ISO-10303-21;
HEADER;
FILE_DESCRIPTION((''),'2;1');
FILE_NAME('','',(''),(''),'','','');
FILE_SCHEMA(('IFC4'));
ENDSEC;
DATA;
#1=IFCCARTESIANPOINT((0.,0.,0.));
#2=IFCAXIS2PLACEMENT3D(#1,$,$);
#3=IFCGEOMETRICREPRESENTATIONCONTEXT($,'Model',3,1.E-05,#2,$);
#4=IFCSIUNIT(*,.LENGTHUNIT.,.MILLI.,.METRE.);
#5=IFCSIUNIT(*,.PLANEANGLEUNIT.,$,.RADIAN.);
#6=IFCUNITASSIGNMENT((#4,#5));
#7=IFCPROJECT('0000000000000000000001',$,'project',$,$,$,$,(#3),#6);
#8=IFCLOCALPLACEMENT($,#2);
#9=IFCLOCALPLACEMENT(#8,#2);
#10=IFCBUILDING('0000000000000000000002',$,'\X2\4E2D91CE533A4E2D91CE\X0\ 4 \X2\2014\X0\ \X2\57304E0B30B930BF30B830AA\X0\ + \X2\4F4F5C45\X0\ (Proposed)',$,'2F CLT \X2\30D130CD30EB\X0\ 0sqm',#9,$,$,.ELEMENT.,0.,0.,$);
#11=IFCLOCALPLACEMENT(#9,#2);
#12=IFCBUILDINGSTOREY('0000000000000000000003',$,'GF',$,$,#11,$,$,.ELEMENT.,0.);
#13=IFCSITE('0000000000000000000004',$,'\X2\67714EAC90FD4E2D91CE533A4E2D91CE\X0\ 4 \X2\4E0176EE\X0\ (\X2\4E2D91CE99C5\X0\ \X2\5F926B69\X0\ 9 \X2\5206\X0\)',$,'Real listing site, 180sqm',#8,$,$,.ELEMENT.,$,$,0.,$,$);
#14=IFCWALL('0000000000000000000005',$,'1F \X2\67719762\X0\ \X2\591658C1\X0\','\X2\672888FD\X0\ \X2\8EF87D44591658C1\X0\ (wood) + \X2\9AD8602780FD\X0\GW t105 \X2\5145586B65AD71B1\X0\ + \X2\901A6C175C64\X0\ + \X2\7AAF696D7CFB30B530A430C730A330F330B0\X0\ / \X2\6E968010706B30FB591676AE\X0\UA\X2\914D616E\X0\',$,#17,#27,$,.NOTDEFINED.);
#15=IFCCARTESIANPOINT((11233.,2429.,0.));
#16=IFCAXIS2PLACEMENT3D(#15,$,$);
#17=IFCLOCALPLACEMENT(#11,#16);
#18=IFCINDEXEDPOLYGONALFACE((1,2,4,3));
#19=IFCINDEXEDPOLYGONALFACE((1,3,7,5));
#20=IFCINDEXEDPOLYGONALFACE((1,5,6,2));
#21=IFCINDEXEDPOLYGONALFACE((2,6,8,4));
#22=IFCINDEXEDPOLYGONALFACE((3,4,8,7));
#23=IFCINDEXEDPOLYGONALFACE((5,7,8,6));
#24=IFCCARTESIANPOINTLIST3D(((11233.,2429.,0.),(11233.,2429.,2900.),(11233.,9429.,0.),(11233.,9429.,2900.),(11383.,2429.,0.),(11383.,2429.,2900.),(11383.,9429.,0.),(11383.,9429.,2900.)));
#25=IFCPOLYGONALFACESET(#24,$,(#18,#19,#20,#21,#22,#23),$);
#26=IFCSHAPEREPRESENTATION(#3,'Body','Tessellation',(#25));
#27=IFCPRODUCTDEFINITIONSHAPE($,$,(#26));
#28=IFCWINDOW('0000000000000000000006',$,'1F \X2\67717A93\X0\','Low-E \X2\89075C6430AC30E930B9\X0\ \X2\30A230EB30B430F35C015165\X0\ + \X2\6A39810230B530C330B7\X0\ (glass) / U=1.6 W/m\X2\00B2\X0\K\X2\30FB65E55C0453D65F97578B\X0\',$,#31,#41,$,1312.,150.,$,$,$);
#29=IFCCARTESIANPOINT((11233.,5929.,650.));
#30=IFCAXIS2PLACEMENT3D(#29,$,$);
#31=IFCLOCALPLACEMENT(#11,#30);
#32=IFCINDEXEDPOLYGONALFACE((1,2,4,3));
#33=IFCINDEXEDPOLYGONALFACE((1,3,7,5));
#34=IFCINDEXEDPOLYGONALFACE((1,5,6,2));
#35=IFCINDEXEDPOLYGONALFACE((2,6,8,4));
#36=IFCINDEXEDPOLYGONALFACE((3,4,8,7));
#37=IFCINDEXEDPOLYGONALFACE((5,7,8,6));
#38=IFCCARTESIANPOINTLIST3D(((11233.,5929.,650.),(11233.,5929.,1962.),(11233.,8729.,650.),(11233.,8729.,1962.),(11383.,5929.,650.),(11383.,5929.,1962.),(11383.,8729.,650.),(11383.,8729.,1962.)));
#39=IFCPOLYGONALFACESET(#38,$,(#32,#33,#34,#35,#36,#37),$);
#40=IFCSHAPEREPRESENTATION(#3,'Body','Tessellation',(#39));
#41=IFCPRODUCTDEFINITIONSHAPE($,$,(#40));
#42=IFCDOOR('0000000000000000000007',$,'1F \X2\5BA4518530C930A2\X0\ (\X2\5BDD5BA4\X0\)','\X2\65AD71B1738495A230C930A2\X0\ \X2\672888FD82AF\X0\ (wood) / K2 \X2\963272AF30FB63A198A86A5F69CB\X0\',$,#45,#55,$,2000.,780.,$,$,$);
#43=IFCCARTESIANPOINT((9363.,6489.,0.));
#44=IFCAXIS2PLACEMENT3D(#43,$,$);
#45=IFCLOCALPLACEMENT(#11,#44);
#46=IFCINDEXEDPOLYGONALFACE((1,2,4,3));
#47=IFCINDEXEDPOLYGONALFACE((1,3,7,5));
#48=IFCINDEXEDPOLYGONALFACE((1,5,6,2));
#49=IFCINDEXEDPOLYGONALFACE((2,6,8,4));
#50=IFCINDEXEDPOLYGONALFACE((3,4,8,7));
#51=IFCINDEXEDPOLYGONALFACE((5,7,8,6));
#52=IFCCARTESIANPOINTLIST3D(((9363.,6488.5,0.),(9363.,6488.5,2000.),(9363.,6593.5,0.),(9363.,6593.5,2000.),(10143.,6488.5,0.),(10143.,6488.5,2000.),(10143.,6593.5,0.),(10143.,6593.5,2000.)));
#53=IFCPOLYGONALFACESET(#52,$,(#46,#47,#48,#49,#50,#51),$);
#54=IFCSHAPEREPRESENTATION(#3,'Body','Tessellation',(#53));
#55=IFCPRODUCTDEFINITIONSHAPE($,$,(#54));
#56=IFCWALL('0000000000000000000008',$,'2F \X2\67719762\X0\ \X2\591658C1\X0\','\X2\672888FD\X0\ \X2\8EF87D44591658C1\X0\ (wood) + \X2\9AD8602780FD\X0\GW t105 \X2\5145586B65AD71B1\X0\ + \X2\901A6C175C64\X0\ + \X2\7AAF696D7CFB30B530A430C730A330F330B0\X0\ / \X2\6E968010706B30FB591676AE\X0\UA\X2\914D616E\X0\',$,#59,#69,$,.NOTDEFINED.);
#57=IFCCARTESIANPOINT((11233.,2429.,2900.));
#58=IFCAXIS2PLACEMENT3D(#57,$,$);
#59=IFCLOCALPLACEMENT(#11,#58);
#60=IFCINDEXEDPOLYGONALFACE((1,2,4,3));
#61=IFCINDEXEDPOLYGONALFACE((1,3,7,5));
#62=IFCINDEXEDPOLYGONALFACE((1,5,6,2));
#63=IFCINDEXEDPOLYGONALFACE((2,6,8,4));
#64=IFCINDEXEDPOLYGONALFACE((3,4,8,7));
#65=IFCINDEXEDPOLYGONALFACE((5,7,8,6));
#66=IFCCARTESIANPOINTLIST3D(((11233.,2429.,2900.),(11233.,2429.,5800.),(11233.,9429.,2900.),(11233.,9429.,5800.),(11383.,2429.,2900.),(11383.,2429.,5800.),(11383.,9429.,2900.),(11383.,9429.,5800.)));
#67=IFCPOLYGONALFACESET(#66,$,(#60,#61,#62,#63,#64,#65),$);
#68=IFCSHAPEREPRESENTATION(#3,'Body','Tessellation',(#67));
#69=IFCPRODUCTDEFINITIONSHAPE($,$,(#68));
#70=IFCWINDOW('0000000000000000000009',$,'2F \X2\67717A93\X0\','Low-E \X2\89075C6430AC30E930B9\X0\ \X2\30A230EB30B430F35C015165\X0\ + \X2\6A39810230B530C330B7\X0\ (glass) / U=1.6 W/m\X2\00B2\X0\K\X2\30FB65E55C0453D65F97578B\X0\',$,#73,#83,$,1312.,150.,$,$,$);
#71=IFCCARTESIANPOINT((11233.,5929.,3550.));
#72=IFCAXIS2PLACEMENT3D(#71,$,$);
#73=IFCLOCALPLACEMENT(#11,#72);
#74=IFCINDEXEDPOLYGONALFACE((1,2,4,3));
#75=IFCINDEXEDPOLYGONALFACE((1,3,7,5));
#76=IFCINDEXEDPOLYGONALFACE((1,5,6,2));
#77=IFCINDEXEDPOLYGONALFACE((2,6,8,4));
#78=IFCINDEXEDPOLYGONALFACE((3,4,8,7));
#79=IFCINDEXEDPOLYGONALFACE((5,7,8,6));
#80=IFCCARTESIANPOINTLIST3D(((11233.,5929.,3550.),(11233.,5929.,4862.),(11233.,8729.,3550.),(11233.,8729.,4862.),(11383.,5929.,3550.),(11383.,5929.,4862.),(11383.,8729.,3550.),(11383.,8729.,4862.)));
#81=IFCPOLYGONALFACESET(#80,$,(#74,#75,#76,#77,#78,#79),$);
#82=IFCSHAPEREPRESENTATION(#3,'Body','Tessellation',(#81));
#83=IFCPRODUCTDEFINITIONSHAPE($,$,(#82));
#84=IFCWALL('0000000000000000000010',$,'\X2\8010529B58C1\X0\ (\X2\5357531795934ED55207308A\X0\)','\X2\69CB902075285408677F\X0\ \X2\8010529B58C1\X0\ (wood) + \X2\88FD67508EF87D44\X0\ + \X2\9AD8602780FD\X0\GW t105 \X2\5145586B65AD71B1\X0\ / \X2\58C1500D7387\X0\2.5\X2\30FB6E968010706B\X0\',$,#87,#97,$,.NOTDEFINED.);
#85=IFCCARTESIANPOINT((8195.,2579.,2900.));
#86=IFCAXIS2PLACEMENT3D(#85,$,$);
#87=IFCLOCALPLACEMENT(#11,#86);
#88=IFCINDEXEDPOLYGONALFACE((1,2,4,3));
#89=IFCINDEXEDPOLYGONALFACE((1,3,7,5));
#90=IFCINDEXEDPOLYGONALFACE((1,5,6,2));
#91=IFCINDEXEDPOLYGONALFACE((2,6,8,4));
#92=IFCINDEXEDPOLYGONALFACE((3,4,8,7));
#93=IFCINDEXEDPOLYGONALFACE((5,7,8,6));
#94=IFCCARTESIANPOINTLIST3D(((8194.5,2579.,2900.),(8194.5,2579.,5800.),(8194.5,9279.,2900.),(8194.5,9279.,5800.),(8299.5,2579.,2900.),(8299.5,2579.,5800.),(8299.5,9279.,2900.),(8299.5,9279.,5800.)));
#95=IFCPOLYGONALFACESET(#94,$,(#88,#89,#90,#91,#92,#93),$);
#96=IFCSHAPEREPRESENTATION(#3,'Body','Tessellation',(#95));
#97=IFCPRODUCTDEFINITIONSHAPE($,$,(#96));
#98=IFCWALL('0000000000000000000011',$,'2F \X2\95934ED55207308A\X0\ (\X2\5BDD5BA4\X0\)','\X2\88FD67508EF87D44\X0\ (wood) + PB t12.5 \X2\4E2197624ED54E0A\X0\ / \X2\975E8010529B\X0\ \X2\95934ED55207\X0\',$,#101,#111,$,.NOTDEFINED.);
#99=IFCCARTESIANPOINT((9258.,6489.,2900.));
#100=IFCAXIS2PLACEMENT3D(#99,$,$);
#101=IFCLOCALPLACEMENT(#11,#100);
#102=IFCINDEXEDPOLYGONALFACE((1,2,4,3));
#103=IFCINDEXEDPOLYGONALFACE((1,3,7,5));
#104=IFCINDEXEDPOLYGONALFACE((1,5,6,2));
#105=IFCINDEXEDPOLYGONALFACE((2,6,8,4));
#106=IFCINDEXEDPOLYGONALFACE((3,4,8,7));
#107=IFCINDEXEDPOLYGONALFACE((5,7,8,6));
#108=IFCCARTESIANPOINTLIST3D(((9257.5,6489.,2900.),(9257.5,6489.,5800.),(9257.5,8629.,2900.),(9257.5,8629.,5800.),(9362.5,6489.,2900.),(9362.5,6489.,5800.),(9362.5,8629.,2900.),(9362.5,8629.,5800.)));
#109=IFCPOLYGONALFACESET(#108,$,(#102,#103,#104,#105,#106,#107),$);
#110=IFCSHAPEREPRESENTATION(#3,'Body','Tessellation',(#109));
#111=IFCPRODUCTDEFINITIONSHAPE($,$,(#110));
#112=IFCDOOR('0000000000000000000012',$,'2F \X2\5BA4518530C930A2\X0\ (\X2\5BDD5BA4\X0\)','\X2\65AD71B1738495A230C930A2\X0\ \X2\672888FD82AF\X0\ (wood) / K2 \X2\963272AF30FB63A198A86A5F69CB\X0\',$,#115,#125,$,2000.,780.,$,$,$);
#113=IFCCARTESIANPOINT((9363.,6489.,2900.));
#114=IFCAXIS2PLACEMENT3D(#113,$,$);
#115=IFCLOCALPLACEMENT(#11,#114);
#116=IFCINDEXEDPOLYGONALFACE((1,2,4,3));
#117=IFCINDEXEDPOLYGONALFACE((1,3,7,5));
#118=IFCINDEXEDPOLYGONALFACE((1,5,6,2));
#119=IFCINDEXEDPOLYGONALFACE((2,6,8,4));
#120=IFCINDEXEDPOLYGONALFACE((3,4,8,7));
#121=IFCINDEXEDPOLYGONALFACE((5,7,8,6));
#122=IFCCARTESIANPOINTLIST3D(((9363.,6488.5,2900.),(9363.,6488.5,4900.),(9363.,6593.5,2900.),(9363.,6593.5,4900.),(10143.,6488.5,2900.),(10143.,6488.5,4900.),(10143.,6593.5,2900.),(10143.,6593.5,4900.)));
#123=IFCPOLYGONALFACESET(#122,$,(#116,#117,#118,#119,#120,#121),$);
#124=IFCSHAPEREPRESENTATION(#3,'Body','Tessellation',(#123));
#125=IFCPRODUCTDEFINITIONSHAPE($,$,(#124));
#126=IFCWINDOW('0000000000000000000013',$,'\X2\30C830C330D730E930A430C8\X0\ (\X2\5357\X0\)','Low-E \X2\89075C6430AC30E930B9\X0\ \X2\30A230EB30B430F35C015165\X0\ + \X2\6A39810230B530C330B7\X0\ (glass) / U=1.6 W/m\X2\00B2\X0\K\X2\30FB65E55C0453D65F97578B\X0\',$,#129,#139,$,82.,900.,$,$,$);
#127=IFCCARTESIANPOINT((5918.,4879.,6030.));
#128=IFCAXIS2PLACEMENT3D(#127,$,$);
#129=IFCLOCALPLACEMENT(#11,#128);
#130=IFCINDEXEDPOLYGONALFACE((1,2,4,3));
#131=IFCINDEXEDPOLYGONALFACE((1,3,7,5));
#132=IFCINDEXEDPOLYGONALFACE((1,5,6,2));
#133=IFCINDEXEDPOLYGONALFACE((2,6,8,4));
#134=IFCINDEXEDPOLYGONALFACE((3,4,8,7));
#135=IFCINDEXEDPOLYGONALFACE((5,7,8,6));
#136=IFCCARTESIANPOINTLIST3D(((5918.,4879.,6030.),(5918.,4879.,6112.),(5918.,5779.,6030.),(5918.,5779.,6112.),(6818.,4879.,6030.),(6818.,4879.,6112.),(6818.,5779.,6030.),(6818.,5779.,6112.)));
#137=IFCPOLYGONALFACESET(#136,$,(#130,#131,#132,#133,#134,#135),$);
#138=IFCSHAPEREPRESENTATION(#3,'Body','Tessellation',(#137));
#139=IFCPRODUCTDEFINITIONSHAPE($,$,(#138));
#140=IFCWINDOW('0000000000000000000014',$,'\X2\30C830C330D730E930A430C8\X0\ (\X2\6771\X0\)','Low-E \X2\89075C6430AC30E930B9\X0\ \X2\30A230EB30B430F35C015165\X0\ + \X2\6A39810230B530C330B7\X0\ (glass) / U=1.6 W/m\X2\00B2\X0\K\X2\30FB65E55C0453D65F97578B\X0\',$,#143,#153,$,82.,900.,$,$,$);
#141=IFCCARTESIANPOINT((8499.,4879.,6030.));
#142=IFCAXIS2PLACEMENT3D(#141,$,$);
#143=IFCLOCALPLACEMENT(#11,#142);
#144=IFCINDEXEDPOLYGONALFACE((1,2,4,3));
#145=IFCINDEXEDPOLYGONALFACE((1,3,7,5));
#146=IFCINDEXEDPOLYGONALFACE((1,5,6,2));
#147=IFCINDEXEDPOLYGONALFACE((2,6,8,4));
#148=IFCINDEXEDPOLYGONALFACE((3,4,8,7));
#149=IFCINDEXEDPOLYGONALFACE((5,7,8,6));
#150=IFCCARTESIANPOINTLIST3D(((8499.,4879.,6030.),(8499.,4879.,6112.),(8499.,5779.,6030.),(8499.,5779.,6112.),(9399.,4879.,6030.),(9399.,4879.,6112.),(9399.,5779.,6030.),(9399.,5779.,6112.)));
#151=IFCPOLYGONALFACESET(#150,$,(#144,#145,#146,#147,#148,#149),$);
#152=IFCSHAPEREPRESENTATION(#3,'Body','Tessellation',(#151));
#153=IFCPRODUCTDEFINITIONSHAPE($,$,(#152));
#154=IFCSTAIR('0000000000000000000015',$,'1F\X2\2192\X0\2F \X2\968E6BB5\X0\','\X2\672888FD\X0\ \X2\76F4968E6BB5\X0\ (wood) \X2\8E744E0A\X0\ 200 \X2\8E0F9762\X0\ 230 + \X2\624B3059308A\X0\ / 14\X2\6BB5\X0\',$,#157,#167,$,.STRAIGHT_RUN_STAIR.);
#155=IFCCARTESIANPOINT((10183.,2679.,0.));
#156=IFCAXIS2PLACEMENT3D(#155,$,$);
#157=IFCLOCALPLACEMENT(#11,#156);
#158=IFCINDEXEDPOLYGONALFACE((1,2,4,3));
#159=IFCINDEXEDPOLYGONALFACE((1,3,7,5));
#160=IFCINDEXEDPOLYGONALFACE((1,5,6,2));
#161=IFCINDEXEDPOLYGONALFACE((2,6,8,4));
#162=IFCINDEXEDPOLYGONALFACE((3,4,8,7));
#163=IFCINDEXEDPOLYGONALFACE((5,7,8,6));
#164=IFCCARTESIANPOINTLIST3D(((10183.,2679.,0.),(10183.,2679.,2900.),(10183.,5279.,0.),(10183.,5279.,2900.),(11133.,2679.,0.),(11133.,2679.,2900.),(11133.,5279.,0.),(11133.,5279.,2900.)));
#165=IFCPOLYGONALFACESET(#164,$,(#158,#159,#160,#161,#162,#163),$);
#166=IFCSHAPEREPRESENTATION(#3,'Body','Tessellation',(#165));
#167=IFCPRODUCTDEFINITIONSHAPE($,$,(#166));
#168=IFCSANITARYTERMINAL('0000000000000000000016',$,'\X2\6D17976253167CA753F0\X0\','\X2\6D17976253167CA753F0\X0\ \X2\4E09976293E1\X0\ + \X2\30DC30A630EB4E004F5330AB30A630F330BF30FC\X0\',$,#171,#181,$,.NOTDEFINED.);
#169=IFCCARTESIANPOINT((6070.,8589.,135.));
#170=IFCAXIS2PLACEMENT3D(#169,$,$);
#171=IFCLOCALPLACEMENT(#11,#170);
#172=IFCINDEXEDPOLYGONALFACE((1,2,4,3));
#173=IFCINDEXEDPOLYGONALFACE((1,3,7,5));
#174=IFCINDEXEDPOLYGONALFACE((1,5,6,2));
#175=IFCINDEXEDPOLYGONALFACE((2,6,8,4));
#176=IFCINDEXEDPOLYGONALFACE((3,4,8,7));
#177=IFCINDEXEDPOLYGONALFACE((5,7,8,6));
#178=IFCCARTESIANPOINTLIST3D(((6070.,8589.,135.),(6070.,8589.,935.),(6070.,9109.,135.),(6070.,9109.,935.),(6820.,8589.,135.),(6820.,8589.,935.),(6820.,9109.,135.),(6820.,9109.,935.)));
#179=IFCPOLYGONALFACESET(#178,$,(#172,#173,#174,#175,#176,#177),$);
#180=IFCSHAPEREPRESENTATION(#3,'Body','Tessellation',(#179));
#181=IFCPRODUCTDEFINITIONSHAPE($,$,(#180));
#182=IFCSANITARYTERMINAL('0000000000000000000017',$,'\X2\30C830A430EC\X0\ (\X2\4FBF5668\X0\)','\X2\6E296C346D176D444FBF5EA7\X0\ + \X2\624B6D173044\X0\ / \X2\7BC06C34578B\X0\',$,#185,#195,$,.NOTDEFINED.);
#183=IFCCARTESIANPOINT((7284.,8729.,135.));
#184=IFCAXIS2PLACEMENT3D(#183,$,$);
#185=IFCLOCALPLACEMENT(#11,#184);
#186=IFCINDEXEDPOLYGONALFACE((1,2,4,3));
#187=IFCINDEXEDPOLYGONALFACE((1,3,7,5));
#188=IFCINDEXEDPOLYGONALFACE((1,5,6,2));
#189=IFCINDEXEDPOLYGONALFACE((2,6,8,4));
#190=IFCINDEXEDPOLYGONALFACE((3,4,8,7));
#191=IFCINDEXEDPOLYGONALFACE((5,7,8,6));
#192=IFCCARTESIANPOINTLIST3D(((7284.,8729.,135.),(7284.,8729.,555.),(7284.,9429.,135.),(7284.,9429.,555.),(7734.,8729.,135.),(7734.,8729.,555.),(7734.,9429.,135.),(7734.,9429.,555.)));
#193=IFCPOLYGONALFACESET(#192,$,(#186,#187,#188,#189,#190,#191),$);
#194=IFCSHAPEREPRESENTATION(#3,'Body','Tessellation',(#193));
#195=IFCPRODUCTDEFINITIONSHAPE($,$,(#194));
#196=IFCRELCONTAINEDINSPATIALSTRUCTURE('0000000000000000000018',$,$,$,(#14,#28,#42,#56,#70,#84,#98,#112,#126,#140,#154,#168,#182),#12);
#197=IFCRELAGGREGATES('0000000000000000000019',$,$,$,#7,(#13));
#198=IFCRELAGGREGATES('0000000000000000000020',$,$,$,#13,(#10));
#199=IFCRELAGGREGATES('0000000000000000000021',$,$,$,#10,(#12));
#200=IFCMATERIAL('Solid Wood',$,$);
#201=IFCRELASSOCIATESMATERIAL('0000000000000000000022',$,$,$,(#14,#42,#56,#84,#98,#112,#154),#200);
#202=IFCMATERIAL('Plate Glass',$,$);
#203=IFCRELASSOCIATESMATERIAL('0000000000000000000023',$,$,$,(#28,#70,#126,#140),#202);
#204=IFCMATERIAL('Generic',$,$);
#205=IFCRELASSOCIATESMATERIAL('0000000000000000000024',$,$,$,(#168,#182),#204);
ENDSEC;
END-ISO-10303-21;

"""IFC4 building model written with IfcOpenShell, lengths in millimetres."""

from ifc_helpers import new_model, si_unit, frame, frame_2d, origin, place, context, project, spatial, rectangle, extrude, material, element, fill, save


model = new_model("IFC4")

# Units and contexts
model_context = context("Model", 3, precision=1e-05, world=origin())
ifc_project = project(units=[si_unit("LENGTHUNIT", "METRE", prefix="MILLI"), si_unit("PLANEANGLEUNIT", "RADIAN")], contexts=[model_context])

# Site, building, storey
site_placement = place(None, origin())
site = spatial("IfcSite", under=ifc_project, at=site_placement, Name="東京都中野区中野 4 丁目 (中野駅 徒歩 9 分)", ObjectType="Real listing site, 180sqm", CompositionType="ELEMENT", RefElevation=0.0)
building_placement = place(site_placement, origin())
building = spatial("IfcBuilding", under=site, at=building_placement, Name="中野区中野 4 — 地下スタジオ + 住居 (Proposed)", ObjectType="2F CLT パネル 0sqm", CompositionType="ELEMENT", ElevationOfRefHeight=0.0, ElevationOfTerrain=0.0)
storey_placement = place(building_placement, origin())
storey = spatial("IfcBuildingStorey", under=building, at=storey_placement, Name="GF", CompositionType="ELEMENT", Elevation=0.0)

# Wall, opening, window
ifc_material_1 = material(Name="Solid Wood")
wall_1_placement = place(storey_placement, frame((11233.0, 2429.0, 0.0)))
wall_1 = element("IfcWall", 1, at=wall_1_placement, inside=storey, material=ifc_material_1, Name="1F 東面 外壁", Description="木製 軸組外壁 (wood) + 高性能GW t105 充填断熱 + 通気層 + 窯業系サイディング / 準耐火・外皮UA配慮", PredefinedType="NOTDEFINED", context=model_context, shape_type="SweptSolid", body=[
    extrude(rectangle(XDim=150.0, YDim=7000.0, at=frame_2d((75.0, 3500.0))), frame((11233.0, 2429.0, 0.0)), (0.0, 0.0, 1.0), 2900.0),
])
opening_1_placement = place(storey_placement, frame((11233.0, 5929.0, 650.0)))
opening_1 = element("IfcOpeningElement", 2, at=opening_1_placement, cuts=wall_1, PredefinedType="NOTDEFINED", context=model_context, shape_type="SweptSolid", body=[
    extrude(rectangle(XDim=150.0, YDim=2800.0, at=frame_2d((75.0, 1400.0))), frame((11233.0, 5929.0, 650.0)), (0.0, 0.0, 1.0), 1312.0),
])
ifc_material_2 = material(Name="Plate Glass")
window_1_placement = place(storey_placement, frame((11233.0, 5929.0, 650.0)))
window_1 = element("IfcWindow", 3, at=window_1_placement, inside=storey, material=ifc_material_2, Name="1F 東窓", Description="Low-E 複層ガラス アルゴン封入 + 樹脂サッシ (glass) / U=1.6 W/m²K・日射取得型", OverallHeight=1312.0, OverallWidth=150.0, context=model_context, shape_type="SweptSolid", body=[
    extrude(rectangle(XDim=150.0, YDim=2800.0, at=frame_2d((75.0, 1400.0))), frame((11233.0, 5929.0, 650.0)), (0.0, 0.0, 1.0), 1312.0),
])
fill(opening_1, window_1)

# Door
door_1_placement = place(storey_placement, frame((9363.0, 6489.0, 0.0)))
element("IfcDoor", 4, at=door_1_placement, inside=storey, material=ifc_material_1, Name="1F 室内ドア (寝室)", Description="断熱玄関ドア 木製芯 (wood) / K2 防犯・採風機構", OverallHeight=2000.0, OverallWidth=780.0, context=model_context, shape_type="SweptSolid", body=[
    extrude(rectangle(XDim=780.0, YDim=105.0, at=frame_2d((390.0, 52.0))), frame((9363.0, 6489.0, 0.0)), (0.0, 0.0, 1.0), 2000.0),
])

# Wall, opening, window
wall_2_placement = place(storey_placement, frame((11233.0, 2429.0, 2900.0)))
wall_2 = element("IfcWall", 5, at=wall_2_placement, inside=storey, material=ifc_material_1, Name="2F 東面 外壁", Description="木製 軸組外壁 (wood) + 高性能GW t105 充填断熱 + 通気層 + 窯業系サイディング / 準耐火・外皮UA配慮", PredefinedType="NOTDEFINED", context=model_context, shape_type="SweptSolid", body=[
    extrude(rectangle(XDim=150.0, YDim=7000.0, at=frame_2d((75.0, 3500.0))), frame((11233.0, 2429.0, 2900.0)), (0.0, 0.0, 1.0), 2900.0),
])
opening_2_placement = place(storey_placement, frame((11233.0, 5929.0, 3550.0)))
opening_2 = element("IfcOpeningElement", 6, at=opening_2_placement, cuts=wall_2, PredefinedType="NOTDEFINED", context=model_context, shape_type="SweptSolid", body=[
    extrude(rectangle(XDim=150.0, YDim=2800.0, at=frame_2d((75.0, 1400.0))), frame((11233.0, 5929.0, 3550.0)), (0.0, 0.0, 1.0), 1312.0),
])
window_2_placement = place(storey_placement, frame((11233.0, 5929.0, 3550.0)))
window_2 = element("IfcWindow", 7, at=window_2_placement, inside=storey, material=ifc_material_2, Name="2F 東窓", Description="Low-E 複層ガラス アルゴン封入 + 樹脂サッシ (glass) / U=1.6 W/m²K・日射取得型", OverallHeight=1312.0, OverallWidth=150.0, context=model_context, shape_type="SweptSolid", body=[
    extrude(rectangle(XDim=150.0, YDim=2800.0, at=frame_2d((75.0, 1400.0))), frame((11233.0, 5929.0, 3550.0)), (0.0, 0.0, 1.0), 1312.0),
])
fill(opening_2, window_2)

# Walls
wall_3_placement = place(storey_placement, frame((8195.0, 2579.0, 2900.0)))
element("IfcWall", 8, at=wall_3_placement, inside=storey, material=ifc_material_1, Name="耐力壁 (南北間仕切り)", Description="構造用合板 耐力壁 (wood) + 製材軸組 + 高性能GW t105 充填断熱 / 壁倍率2.5・準耐火", PredefinedType="NOTDEFINED", context=model_context, shape_type="SweptSolid", body=[
    extrude(rectangle(XDim=105.0, YDim=6700.0, at=frame_2d((52.0, 3350.0))), frame((8195.0, 2579.0, 2900.0)), (0.0, 0.0, 1.0), 2900.0),
])
wall_4_placement = place(storey_placement, frame((9258.0, 6489.0, 2900.0)))
element("IfcWall", 9, at=wall_4_placement, inside=storey, material=ifc_material_1, Name="2F 間仕切り (寝室)", Description="製材軸組 (wood) + PB t12.5 両面仕上 / 非耐力 間仕切", PredefinedType="NOTDEFINED", context=model_context, shape_type="SweptSolid", body=[
    extrude(rectangle(XDim=105.0, YDim=2140.0, at=frame_2d((52.0, 1070.0))), frame((9258.0, 6489.0, 2900.0)), (0.0, 0.0, 1.0), 2900.0),
])

# Door
door_2_placement = place(storey_placement, frame((9363.0, 6489.0, 2900.0)))
element("IfcDoor", 10, at=door_2_placement, inside=storey, material=ifc_material_1, Name="2F 室内ドア (寝室)", Description="断熱玄関ドア 木製芯 (wood) / K2 防犯・採風機構", OverallHeight=2000.0, OverallWidth=780.0, context=model_context, shape_type="SweptSolid", body=[
    extrude(rectangle(XDim=780.0, YDim=105.0, at=frame_2d((390.0, 52.0))), frame((9363.0, 6489.0, 2900.0)), (0.0, 0.0, 1.0), 2000.0),
])

# Windows
window_3_placement = place(storey_placement, frame((5918.0, 4879.0, 6030.0)))
element("IfcWindow", 11, at=window_3_placement, inside=storey, material=ifc_material_2, Name="トップライト (南)", Description="Low-E 複層ガラス アルゴン封入 + 樹脂サッシ (glass) / U=1.6 W/m²K・日射取得型", OverallHeight=82.0, OverallWidth=900.0, context=model_context, shape_type="SweptSolid", body=[
    extrude(rectangle(XDim=900.0, YDim=900.0, at=frame_2d((450.0, 450.0))), frame((5918.0, 4879.0, 6030.0)), (0.0, 0.0, 1.0), 82.0),
])
window_4_placement = place(storey_placement, frame((8499.0, 4879.0, 6030.0)))
element("IfcWindow", 12, at=window_4_placement, inside=storey, material=ifc_material_2, Name="トップライト (東)", Description="Low-E 複層ガラス アルゴン封入 + 樹脂サッシ (glass) / U=1.6 W/m²K・日射取得型", OverallHeight=82.0, OverallWidth=900.0, context=model_context, shape_type="SweptSolid", body=[
    extrude(rectangle(XDim=900.0, YDim=900.0, at=frame_2d((450.0, 450.0))), frame((8499.0, 4879.0, 6030.0)), (0.0, 0.0, 1.0), 82.0),
])

# Stair
stair_placement = place(storey_placement, frame((10183.0, 2679.0, 0.0)))
element("IfcStair", 13, at=stair_placement, inside=storey, material=ifc_material_1, Name="1F→2F 階段", Description="木製 直階段 (wood) 蹴上 200 踏面 230 + 手すり / 14段", PredefinedType="STRAIGHT_RUN_STAIR", context=model_context, shape_type="SweptSolid", body=[
    extrude(rectangle(XDim=950.0, YDim=2600.0, at=frame_2d((475.0, 1300.0))), frame((10183.0, 2679.0, 0.0)), (0.0, 0.0, 1.0), 2900.0),
])

# Sanitary terminals
ifc_material_3 = material(Name="Generic")
sanitary_terminal_1_placement = place(storey_placement, frame((6070.0, 8589.0, 135.0)))
element("IfcSanitaryTerminal", 14, at=sanitary_terminal_1_placement, inside=storey, material=ifc_material_3, Name="洗面化粧台", Description="洗面化粧台 三面鏡 + ボウル一体カウンター", PredefinedType="NOTDEFINED", context=model_context, shape_type="SweptSolid", body=[
    extrude(rectangle(XDim=750.0, YDim=520.0, at=frame_2d((375.0, 260.0))), frame((6070.0, 8589.0, 135.0)), (0.0, 0.0, 1.0), 800.0),
])
sanitary_terminal_2_placement = place(storey_placement, frame((7284.0, 8729.0, 135.0)))
element("IfcSanitaryTerminal", 15, at=sanitary_terminal_2_placement, inside=storey, material=ifc_material_3, Name="トイレ (便器)", Description="温水洗浄便座 + 手洗い / 節水型", PredefinedType="NOTDEFINED", context=model_context, shape_type="SweptSolid", body=[
    extrude(rectangle(XDim=450.0, YDim=700.0, at=frame_2d((225.0, 350.0))), frame((7284.0, 8729.0, 135.0)), (0.0, 0.0, 1.0), 420.0),
])

save(model, "model.ifc")
